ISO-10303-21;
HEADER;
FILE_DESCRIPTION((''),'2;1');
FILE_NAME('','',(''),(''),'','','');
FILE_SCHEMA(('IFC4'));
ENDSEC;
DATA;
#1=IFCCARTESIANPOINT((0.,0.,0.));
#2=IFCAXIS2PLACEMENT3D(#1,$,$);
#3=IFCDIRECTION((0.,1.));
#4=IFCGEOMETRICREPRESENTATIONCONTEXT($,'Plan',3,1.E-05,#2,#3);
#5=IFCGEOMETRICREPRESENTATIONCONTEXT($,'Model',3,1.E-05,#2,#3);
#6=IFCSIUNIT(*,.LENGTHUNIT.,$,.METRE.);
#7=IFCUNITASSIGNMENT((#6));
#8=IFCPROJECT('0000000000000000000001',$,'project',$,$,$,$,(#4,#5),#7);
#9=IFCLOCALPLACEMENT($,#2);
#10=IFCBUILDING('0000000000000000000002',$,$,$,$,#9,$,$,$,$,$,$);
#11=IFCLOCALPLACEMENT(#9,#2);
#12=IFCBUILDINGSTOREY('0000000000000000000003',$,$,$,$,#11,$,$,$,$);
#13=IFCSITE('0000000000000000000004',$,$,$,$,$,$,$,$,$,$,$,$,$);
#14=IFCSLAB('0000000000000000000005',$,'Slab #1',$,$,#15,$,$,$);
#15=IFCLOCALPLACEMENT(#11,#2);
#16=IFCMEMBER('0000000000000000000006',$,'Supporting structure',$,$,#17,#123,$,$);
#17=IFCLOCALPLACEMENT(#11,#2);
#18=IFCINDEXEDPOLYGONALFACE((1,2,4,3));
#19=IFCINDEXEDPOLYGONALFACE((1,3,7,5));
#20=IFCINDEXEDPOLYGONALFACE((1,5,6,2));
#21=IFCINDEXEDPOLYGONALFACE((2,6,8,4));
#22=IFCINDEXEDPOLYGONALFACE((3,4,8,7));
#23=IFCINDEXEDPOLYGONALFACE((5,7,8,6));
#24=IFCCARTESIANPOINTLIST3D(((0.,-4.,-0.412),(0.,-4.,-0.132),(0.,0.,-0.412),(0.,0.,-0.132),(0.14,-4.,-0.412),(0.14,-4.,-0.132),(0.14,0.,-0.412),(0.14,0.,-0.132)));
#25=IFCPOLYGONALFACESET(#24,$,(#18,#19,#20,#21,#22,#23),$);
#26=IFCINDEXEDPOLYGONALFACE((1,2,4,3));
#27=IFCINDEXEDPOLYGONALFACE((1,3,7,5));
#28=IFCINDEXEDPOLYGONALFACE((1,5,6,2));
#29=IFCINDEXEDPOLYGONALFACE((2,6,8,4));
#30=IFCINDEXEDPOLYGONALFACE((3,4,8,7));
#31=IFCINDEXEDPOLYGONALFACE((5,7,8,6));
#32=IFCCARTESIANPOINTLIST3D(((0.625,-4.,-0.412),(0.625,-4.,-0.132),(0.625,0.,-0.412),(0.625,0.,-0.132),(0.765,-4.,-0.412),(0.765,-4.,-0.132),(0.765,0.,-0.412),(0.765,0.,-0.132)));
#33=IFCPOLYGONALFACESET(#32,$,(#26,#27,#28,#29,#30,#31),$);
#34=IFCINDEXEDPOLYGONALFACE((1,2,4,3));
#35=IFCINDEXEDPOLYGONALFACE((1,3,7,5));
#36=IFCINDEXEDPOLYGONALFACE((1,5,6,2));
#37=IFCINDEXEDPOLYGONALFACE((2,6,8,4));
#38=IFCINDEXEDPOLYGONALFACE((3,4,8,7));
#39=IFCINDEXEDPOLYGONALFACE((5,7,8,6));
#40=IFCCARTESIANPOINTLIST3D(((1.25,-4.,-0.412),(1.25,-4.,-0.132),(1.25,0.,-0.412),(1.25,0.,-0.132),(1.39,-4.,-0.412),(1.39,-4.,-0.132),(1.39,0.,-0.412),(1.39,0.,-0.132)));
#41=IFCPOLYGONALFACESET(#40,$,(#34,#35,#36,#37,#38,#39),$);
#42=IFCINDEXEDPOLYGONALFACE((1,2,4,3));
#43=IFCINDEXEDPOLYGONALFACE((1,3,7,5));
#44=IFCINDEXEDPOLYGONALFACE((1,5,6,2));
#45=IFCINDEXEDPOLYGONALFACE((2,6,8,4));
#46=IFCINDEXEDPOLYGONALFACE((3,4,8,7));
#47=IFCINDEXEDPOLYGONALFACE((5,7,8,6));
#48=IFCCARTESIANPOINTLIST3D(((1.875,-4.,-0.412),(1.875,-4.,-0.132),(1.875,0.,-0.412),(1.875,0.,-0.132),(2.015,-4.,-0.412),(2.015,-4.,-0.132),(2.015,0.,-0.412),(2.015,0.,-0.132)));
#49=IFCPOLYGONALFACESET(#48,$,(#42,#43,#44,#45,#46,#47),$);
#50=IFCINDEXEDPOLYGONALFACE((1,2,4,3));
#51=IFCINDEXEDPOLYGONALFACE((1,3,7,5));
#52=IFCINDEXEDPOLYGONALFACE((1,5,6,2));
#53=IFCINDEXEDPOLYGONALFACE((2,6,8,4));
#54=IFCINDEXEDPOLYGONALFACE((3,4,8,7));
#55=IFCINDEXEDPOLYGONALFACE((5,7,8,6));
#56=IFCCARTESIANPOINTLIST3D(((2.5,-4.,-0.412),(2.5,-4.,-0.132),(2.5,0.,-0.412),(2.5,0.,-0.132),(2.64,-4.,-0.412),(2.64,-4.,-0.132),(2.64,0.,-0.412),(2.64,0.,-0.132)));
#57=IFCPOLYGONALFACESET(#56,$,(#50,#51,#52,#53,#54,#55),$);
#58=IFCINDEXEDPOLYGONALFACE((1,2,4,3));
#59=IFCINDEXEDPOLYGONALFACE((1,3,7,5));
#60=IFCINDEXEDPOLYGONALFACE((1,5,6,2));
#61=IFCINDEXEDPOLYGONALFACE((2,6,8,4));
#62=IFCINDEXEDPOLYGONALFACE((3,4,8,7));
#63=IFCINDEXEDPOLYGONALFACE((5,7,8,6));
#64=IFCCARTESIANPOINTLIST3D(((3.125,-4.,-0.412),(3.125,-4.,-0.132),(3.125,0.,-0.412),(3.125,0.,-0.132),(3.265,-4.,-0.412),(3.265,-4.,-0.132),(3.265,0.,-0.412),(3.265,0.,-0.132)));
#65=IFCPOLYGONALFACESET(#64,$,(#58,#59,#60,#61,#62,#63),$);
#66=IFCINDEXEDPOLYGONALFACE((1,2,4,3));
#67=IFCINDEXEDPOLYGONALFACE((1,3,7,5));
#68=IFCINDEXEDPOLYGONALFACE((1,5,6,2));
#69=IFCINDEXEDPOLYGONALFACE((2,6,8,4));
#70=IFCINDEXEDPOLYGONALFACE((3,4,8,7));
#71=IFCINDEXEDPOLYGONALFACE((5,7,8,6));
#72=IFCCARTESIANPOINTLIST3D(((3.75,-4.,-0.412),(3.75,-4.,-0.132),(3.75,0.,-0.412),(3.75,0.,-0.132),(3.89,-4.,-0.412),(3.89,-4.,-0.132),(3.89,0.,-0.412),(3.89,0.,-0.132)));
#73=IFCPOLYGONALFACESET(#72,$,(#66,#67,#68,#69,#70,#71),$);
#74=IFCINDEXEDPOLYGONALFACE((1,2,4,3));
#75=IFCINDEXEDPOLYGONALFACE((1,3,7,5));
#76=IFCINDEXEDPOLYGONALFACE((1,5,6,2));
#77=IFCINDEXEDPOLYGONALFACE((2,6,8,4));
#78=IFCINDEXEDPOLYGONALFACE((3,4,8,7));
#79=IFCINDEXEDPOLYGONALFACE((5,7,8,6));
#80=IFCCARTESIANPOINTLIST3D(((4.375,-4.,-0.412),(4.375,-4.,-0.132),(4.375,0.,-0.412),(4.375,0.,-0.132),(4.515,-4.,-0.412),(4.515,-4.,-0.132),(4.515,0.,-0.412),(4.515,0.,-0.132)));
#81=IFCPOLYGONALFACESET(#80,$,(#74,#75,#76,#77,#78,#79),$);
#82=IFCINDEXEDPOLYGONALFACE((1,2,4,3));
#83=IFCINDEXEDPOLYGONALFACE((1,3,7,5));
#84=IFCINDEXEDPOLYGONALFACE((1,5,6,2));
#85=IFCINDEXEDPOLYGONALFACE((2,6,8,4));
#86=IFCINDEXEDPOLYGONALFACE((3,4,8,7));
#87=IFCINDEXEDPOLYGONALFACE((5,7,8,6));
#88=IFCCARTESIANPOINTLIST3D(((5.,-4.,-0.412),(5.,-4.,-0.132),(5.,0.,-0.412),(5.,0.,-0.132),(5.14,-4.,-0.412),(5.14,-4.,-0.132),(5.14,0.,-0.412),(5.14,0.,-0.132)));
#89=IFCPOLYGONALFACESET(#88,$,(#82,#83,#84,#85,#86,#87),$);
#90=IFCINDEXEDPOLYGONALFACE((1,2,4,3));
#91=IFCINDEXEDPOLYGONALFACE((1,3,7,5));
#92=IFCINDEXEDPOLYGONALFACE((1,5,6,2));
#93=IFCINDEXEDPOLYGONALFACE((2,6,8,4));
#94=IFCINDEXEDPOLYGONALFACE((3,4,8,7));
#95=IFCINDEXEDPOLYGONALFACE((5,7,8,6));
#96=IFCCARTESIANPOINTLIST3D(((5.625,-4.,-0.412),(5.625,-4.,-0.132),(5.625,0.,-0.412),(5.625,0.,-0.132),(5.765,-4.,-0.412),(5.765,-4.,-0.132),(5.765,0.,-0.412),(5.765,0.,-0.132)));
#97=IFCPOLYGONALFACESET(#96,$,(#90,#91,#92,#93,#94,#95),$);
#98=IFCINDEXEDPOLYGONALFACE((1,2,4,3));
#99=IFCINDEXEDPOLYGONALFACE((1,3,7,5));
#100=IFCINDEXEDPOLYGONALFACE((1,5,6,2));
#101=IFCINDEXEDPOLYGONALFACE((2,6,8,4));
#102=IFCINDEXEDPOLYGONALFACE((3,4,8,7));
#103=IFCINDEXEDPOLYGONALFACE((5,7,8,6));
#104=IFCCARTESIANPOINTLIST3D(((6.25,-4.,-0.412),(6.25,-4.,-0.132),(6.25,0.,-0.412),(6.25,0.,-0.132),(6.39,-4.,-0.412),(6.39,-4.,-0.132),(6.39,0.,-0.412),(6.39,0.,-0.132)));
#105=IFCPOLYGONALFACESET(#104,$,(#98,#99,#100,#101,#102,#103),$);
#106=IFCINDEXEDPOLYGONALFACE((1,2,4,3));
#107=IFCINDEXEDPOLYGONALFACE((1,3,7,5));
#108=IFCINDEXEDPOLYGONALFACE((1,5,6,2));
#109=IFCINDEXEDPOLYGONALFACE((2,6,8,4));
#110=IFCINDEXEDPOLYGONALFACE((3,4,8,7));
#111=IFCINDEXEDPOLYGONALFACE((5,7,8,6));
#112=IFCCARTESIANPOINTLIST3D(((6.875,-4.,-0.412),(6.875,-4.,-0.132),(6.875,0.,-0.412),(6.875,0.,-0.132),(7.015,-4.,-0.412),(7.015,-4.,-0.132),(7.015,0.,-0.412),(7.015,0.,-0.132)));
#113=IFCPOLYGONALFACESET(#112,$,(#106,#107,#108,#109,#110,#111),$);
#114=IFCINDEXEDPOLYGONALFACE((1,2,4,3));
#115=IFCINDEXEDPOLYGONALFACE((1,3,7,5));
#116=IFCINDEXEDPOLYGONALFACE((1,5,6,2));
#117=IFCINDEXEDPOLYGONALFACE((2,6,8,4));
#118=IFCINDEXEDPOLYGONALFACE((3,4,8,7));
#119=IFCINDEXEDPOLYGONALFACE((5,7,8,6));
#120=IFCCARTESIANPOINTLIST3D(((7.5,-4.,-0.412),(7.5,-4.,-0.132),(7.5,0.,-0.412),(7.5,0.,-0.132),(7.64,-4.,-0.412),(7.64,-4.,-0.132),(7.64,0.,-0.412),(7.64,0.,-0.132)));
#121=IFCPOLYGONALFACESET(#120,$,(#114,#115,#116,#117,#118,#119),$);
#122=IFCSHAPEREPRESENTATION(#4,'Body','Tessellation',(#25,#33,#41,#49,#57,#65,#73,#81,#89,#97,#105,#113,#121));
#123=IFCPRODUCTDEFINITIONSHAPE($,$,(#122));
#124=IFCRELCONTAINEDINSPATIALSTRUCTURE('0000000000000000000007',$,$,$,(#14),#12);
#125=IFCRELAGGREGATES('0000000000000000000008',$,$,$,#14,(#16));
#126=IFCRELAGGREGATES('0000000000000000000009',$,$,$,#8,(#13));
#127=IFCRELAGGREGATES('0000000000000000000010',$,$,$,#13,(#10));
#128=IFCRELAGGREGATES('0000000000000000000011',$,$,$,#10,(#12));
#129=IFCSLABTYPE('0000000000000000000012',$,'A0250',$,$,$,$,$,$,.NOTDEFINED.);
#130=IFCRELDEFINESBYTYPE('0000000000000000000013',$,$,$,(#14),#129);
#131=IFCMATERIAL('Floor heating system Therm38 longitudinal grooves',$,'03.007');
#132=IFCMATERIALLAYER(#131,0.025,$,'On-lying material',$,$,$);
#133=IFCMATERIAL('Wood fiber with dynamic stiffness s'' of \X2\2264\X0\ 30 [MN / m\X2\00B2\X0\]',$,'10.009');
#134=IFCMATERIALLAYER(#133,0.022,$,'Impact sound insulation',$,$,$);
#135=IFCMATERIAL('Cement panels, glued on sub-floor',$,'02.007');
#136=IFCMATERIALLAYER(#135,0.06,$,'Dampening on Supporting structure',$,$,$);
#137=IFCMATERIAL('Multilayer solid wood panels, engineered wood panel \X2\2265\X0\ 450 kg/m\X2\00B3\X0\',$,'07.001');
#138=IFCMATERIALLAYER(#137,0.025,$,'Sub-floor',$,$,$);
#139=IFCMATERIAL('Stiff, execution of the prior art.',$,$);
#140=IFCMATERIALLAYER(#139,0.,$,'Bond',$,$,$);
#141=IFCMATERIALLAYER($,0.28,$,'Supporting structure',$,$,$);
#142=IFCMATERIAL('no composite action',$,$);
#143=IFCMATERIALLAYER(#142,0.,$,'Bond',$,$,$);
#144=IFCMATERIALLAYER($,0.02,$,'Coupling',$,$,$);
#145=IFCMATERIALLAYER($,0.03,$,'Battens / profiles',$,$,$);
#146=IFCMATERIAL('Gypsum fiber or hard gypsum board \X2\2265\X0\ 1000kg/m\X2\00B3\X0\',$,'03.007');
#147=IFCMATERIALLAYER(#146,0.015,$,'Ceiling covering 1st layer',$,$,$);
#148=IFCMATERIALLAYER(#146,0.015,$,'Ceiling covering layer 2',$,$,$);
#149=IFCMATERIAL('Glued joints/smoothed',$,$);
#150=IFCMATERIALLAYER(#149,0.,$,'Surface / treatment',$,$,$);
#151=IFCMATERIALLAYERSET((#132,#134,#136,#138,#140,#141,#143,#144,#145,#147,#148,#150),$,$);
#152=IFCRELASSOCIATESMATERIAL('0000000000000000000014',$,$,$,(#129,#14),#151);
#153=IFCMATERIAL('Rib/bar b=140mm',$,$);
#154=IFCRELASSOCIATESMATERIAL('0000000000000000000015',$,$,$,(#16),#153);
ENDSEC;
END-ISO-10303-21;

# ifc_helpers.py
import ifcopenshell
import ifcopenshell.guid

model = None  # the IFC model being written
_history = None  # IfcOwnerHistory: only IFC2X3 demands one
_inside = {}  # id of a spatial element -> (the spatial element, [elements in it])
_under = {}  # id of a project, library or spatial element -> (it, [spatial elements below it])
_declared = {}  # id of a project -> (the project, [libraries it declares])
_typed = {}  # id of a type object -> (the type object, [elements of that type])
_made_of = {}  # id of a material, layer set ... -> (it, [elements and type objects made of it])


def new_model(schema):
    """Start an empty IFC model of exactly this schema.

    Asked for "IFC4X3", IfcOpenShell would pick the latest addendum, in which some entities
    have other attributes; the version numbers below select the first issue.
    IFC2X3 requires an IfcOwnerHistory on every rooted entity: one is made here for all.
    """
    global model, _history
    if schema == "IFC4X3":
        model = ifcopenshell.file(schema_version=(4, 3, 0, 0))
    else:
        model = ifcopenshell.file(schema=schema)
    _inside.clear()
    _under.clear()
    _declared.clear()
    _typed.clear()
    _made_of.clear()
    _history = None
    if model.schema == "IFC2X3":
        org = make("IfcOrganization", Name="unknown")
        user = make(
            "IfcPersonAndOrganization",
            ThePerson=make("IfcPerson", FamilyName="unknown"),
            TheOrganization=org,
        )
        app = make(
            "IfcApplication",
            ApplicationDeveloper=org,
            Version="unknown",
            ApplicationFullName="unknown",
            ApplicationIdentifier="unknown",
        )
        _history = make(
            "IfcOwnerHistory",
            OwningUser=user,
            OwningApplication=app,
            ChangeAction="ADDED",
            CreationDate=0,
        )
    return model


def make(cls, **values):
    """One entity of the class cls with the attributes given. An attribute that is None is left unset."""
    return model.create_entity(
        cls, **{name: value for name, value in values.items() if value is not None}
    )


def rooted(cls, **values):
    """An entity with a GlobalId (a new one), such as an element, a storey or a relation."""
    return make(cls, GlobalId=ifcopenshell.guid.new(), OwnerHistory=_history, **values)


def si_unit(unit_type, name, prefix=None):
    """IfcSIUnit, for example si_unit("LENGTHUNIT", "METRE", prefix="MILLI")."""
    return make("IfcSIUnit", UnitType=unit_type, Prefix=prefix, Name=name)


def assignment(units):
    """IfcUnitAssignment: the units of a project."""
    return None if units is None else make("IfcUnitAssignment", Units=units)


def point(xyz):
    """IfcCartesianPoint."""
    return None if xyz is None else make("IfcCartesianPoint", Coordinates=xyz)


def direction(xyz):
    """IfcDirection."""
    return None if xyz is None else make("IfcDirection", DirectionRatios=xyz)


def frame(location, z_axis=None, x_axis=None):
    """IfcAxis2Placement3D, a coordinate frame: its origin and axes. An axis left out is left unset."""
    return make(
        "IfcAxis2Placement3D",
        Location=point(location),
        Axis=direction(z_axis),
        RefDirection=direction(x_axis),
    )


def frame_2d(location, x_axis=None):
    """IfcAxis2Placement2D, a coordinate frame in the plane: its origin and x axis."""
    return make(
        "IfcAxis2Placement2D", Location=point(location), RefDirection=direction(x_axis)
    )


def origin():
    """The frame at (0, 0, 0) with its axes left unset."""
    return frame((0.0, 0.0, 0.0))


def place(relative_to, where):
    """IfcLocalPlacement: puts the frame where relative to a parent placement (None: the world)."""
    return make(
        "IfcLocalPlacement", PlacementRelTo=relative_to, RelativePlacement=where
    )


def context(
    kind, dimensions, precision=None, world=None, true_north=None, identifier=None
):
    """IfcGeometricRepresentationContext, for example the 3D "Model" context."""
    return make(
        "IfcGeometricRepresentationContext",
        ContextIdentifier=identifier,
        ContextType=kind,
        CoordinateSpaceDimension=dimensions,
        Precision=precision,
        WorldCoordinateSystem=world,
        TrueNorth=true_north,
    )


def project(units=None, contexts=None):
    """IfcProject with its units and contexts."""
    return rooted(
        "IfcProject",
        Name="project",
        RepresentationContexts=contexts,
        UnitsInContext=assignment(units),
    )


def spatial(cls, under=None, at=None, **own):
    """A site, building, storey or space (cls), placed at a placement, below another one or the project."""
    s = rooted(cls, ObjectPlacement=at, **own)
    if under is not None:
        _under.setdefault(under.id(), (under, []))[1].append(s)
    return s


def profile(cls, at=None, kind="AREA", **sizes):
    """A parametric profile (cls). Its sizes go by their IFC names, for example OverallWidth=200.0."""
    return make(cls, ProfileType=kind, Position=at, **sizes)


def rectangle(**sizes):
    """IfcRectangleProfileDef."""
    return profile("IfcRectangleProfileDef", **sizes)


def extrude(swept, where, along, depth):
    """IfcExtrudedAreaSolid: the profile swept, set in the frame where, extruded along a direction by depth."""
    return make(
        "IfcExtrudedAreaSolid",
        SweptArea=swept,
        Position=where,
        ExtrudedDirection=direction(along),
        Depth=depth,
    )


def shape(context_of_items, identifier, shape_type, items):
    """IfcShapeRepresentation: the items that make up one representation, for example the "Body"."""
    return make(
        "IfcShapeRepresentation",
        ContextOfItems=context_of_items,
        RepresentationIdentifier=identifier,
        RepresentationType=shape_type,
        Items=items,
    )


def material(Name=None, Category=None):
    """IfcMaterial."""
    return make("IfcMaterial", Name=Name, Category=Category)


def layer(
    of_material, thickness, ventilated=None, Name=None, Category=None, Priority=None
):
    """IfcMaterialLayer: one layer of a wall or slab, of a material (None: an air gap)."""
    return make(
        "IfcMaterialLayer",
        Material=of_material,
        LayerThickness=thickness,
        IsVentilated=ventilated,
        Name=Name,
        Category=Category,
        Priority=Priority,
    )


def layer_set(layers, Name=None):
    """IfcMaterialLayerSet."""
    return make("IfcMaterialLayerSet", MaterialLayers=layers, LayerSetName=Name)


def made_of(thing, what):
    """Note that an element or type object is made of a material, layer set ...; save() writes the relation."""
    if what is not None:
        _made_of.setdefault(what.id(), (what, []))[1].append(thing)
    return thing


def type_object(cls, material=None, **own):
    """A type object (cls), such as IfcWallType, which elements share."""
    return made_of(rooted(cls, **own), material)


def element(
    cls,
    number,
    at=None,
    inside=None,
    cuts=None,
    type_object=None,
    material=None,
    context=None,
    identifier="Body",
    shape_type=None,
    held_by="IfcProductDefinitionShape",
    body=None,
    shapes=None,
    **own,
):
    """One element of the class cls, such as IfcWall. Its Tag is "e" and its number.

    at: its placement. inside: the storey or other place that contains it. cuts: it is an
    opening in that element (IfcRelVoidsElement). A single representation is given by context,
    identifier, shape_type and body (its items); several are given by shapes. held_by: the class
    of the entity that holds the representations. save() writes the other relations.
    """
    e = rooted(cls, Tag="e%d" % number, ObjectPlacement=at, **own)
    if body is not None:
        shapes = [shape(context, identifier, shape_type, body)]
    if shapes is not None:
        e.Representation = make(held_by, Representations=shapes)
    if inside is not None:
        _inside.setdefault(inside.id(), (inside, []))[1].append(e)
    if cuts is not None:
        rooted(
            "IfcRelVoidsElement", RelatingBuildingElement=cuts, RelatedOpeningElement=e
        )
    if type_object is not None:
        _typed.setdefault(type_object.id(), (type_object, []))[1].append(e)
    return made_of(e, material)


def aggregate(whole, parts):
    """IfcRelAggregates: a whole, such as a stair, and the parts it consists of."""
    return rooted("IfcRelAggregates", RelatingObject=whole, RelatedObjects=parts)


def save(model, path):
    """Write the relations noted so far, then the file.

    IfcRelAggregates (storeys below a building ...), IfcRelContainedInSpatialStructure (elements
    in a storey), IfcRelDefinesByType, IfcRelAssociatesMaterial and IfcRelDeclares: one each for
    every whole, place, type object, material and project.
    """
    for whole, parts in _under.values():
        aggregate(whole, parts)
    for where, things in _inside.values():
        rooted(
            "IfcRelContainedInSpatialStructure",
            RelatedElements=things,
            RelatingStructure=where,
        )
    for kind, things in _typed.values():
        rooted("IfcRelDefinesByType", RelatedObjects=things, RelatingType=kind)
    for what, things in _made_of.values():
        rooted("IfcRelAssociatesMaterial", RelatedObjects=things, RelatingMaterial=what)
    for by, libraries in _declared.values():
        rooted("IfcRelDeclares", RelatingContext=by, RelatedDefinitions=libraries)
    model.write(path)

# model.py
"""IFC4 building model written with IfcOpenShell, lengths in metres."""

from ifc_helpers import new_model, si_unit, direction, frame, frame_2d, origin, place, context, project, spatial, rectangle, extrude, material, layer, layer_set, type_object, element, aggregate, save


model = new_model("IFC4")

# Units and contexts
plan_context = context("Plan", 3, precision=1e-05, world=origin(), true_north=direction((0.0, 1.0)))
model_context = context("Model", 3, precision=1e-05, world=origin(), true_north=direction((0.0, 1.0)))
ifc_project = project(units=[si_unit("LENGTHUNIT", "METRE")], contexts=[plan_context, model_context])

# Site, building, storey
site = spatial("IfcSite", under=ifc_project)
building_placement = place(None, origin())
building = spatial("IfcBuilding", under=site, at=building_placement)
storey_placement = place(building_placement, origin())
storey = spatial("IfcBuildingStorey", under=building, at=storey_placement)

# Slab, member
ifc_material_1 = material(Name="Floor heating system Therm38 longitudinal grooves", Category="03.007")
ifc_layer_1 = layer(ifc_material_1, 0.025, Name="On-lying material")
ifc_material_2 = material(Name="Wood fiber with dynamic stiffness s' of ≤ 30 [MN / m²]", Category="10.009")
ifc_layer_2 = layer(ifc_material_2, 0.022, Name="Impact sound insulation")
ifc_material_3 = material(Name="Cement panels, glued on sub-floor", Category="02.007")
ifc_layer_3 = layer(ifc_material_3, 0.06, Name="Dampening on Supporting structure")
ifc_material_4 = material(Name="Multilayer solid wood panels, engineered wood panel ≥ 450 kg/m³", Category="07.001")
ifc_layer_4 = layer(ifc_material_4, 0.025, Name="Sub-floor")
ifc_material_5 = material(Name="Stiff, execution of the prior art.")
ifc_layer_5 = layer(ifc_material_5, 0.0, Name="Bond")
ifc_layer_6 = layer(None, 0.28, Name="Supporting structure")
ifc_material_6 = material(Name="no composite action")
ifc_layer_7 = layer(ifc_material_6, 0.0, Name="Bond")
ifc_layer_8 = layer(None, 0.02, Name="Coupling")
ifc_layer_9 = layer(None, 0.03, Name="Battens / profiles")
ifc_material_7 = material(Name="Gypsum fiber or hard gypsum board ≥ 1000kg/m³", Category="03.007")
ifc_layer_10 = layer(ifc_material_7, 0.015, Name="Ceiling covering 1st layer")
ifc_layer_11 = layer(ifc_material_7, 0.015, Name="Ceiling covering layer 2")
ifc_material_8 = material(Name="Glued joints/smoothed")
ifc_layer_12 = layer(ifc_material_8, 0.0, Name="Surface / treatment")
ifc_layer_set = layer_set([ifc_layer_1, ifc_layer_2, ifc_layer_3, ifc_layer_4, ifc_layer_5, ifc_layer_6, ifc_layer_7, ifc_layer_8, ifc_layer_9, ifc_layer_10, ifc_layer_11, ifc_layer_12])
slab_type = type_object("IfcSlabType", Name="A0250", PredefinedType="NOTDEFINED", material=ifc_layer_set)
slab_placement = place(None, frame((0.0, 0.0, 0.0), z_axis=(0.0, 0.0, -1.0), x_axis=(1.0, 0.0, 0.0)))
slab = element("IfcSlab", 1, at=slab_placement, inside=storey, type_object=slab_type, material=ifc_layer_set, Name="Slab #1")
ifc_material_9 = material(Name="Rib/bar b=140mm")
member_1_placement = place(slab_placement, origin())
member_1 = element("IfcMember", 2, at=member_1_placement, material=ifc_material_9, Name="Supporting structure", context=plan_context, shape_type="SweptSolid", body=[
    extrude(rectangle(XDim=0.14, YDim=0.28, at=frame_2d((0.07, 0.14), x_axis=(1.0, 0.0))), frame((0.0, 4.0, 0.132), z_axis=(0.0, -1.0, 0.0), x_axis=(1.0, 0.0, 0.0)), (0.0, 0.0, 1.0), 4.0),
    extrude(rectangle(XDim=0.14, YDim=0.28, at=frame_2d((0.07, 0.14), x_axis=(1.0, 0.0))), frame((0.625, 4.0, 0.132), z_axis=(0.0, -1.0, 0.0), x_axis=(1.0, 0.0, 0.0)), (0.0, 0.0, 1.0), 4.0),
    extrude(rectangle(XDim=0.14, YDim=0.28, at=frame_2d((0.07, 0.14), x_axis=(1.0, 0.0))), frame((1.25, 4.0, 0.132), z_axis=(0.0, -1.0, 0.0), x_axis=(1.0, 0.0, 0.0)), (0.0, 0.0, 1.0), 4.0),
    extrude(rectangle(XDim=0.14, YDim=0.28, at=frame_2d((0.07, 0.14), x_axis=(1.0, 0.0))), frame((1.875, 4.0, 0.132), z_axis=(0.0, -1.0, 0.0), x_axis=(1.0, 0.0, 0.0)), (0.0, 0.0, 1.0), 4.0),
    extrude(rectangle(XDim=0.14, YDim=0.28, at=frame_2d((0.07, 0.14), x_axis=(1.0, 0.0))), frame((2.5, 4.0, 0.132), z_axis=(0.0, -1.0, 0.0), x_axis=(1.0, 0.0, 0.0)), (0.0, 0.0, 1.0), 4.0),
    extrude(rectangle(XDim=0.14, YDim=0.28, at=frame_2d((0.07, 0.14), x_axis=(1.0, 0.0))), frame((3.125, 4.0, 0.132), z_axis=(0.0, -1.0, 0.0), x_axis=(1.0, 0.0, 0.0)), (0.0, 0.0, 1.0), 4.0),
    extrude(rectangle(XDim=0.14, YDim=0.28, at=frame_2d((0.07, 0.14), x_axis=(1.0, 0.0))), frame((3.75, 4.0, 0.132), z_axis=(0.0, -1.0, 0.0), x_axis=(1.0, 0.0, 0.0)), (0.0, 0.0, 1.0), 4.0),
    extrude(rectangle(XDim=0.14, YDim=0.28, at=frame_2d((0.07, 0.14), x_axis=(1.0, 0.0))), frame((4.375, 4.0, 0.132), z_axis=(0.0, -1.0, 0.0), x_axis=(1.0, 0.0, 0.0)), (0.0, 0.0, 1.0), 4.0),
    extrude(rectangle(XDim=0.14, YDim=0.28, at=frame_2d((0.07, 0.14), x_axis=(1.0, 0.0))), frame((5.0, 4.0, 0.132), z_axis=(0.0, -1.0, 0.0), x_axis=(1.0, 0.0, 0.0)), (0.0, 0.0, 1.0), 4.0),
    extrude(rectangle(XDim=0.14, YDim=0.28, at=frame_2d((0.07, 0.14), x_axis=(1.0, 0.0))), frame((5.625, 4.0, 0.132), z_axis=(0.0, -1.0, 0.0), x_axis=(1.0, 0.0, 0.0)), (0.0, 0.0, 1.0), 4.0),
    extrude(rectangle(XDim=0.14, YDim=0.28, at=frame_2d((0.07, 0.14), x_axis=(1.0, 0.0))), frame((6.25, 4.0, 0.132), z_axis=(0.0, -1.0, 0.0), x_axis=(1.0, 0.0, 0.0)), (0.0, 0.0, 1.0), 4.0),
    extrude(rectangle(XDim=0.14, YDim=0.28, at=frame_2d((0.07, 0.14), x_axis=(1.0, 0.0))), frame((6.875, 4.0, 0.132), z_axis=(0.0, -1.0, 0.0), x_axis=(1.0, 0.0, 0.0)), (0.0, 0.0, 1.0), 4.0),
    extrude(rectangle(XDim=0.14, YDim=0.28, at=frame_2d((0.07, 0.14), x_axis=(1.0, 0.0))), frame((7.5, 4.0, 0.132), z_axis=(0.0, -1.0, 0.0), x_axis=(1.0, 0.0, 0.0)), (0.0, 0.0, 1.0), 4.0),
])
aggregate(slab, [member_1])

save(model, "model.ifc")
